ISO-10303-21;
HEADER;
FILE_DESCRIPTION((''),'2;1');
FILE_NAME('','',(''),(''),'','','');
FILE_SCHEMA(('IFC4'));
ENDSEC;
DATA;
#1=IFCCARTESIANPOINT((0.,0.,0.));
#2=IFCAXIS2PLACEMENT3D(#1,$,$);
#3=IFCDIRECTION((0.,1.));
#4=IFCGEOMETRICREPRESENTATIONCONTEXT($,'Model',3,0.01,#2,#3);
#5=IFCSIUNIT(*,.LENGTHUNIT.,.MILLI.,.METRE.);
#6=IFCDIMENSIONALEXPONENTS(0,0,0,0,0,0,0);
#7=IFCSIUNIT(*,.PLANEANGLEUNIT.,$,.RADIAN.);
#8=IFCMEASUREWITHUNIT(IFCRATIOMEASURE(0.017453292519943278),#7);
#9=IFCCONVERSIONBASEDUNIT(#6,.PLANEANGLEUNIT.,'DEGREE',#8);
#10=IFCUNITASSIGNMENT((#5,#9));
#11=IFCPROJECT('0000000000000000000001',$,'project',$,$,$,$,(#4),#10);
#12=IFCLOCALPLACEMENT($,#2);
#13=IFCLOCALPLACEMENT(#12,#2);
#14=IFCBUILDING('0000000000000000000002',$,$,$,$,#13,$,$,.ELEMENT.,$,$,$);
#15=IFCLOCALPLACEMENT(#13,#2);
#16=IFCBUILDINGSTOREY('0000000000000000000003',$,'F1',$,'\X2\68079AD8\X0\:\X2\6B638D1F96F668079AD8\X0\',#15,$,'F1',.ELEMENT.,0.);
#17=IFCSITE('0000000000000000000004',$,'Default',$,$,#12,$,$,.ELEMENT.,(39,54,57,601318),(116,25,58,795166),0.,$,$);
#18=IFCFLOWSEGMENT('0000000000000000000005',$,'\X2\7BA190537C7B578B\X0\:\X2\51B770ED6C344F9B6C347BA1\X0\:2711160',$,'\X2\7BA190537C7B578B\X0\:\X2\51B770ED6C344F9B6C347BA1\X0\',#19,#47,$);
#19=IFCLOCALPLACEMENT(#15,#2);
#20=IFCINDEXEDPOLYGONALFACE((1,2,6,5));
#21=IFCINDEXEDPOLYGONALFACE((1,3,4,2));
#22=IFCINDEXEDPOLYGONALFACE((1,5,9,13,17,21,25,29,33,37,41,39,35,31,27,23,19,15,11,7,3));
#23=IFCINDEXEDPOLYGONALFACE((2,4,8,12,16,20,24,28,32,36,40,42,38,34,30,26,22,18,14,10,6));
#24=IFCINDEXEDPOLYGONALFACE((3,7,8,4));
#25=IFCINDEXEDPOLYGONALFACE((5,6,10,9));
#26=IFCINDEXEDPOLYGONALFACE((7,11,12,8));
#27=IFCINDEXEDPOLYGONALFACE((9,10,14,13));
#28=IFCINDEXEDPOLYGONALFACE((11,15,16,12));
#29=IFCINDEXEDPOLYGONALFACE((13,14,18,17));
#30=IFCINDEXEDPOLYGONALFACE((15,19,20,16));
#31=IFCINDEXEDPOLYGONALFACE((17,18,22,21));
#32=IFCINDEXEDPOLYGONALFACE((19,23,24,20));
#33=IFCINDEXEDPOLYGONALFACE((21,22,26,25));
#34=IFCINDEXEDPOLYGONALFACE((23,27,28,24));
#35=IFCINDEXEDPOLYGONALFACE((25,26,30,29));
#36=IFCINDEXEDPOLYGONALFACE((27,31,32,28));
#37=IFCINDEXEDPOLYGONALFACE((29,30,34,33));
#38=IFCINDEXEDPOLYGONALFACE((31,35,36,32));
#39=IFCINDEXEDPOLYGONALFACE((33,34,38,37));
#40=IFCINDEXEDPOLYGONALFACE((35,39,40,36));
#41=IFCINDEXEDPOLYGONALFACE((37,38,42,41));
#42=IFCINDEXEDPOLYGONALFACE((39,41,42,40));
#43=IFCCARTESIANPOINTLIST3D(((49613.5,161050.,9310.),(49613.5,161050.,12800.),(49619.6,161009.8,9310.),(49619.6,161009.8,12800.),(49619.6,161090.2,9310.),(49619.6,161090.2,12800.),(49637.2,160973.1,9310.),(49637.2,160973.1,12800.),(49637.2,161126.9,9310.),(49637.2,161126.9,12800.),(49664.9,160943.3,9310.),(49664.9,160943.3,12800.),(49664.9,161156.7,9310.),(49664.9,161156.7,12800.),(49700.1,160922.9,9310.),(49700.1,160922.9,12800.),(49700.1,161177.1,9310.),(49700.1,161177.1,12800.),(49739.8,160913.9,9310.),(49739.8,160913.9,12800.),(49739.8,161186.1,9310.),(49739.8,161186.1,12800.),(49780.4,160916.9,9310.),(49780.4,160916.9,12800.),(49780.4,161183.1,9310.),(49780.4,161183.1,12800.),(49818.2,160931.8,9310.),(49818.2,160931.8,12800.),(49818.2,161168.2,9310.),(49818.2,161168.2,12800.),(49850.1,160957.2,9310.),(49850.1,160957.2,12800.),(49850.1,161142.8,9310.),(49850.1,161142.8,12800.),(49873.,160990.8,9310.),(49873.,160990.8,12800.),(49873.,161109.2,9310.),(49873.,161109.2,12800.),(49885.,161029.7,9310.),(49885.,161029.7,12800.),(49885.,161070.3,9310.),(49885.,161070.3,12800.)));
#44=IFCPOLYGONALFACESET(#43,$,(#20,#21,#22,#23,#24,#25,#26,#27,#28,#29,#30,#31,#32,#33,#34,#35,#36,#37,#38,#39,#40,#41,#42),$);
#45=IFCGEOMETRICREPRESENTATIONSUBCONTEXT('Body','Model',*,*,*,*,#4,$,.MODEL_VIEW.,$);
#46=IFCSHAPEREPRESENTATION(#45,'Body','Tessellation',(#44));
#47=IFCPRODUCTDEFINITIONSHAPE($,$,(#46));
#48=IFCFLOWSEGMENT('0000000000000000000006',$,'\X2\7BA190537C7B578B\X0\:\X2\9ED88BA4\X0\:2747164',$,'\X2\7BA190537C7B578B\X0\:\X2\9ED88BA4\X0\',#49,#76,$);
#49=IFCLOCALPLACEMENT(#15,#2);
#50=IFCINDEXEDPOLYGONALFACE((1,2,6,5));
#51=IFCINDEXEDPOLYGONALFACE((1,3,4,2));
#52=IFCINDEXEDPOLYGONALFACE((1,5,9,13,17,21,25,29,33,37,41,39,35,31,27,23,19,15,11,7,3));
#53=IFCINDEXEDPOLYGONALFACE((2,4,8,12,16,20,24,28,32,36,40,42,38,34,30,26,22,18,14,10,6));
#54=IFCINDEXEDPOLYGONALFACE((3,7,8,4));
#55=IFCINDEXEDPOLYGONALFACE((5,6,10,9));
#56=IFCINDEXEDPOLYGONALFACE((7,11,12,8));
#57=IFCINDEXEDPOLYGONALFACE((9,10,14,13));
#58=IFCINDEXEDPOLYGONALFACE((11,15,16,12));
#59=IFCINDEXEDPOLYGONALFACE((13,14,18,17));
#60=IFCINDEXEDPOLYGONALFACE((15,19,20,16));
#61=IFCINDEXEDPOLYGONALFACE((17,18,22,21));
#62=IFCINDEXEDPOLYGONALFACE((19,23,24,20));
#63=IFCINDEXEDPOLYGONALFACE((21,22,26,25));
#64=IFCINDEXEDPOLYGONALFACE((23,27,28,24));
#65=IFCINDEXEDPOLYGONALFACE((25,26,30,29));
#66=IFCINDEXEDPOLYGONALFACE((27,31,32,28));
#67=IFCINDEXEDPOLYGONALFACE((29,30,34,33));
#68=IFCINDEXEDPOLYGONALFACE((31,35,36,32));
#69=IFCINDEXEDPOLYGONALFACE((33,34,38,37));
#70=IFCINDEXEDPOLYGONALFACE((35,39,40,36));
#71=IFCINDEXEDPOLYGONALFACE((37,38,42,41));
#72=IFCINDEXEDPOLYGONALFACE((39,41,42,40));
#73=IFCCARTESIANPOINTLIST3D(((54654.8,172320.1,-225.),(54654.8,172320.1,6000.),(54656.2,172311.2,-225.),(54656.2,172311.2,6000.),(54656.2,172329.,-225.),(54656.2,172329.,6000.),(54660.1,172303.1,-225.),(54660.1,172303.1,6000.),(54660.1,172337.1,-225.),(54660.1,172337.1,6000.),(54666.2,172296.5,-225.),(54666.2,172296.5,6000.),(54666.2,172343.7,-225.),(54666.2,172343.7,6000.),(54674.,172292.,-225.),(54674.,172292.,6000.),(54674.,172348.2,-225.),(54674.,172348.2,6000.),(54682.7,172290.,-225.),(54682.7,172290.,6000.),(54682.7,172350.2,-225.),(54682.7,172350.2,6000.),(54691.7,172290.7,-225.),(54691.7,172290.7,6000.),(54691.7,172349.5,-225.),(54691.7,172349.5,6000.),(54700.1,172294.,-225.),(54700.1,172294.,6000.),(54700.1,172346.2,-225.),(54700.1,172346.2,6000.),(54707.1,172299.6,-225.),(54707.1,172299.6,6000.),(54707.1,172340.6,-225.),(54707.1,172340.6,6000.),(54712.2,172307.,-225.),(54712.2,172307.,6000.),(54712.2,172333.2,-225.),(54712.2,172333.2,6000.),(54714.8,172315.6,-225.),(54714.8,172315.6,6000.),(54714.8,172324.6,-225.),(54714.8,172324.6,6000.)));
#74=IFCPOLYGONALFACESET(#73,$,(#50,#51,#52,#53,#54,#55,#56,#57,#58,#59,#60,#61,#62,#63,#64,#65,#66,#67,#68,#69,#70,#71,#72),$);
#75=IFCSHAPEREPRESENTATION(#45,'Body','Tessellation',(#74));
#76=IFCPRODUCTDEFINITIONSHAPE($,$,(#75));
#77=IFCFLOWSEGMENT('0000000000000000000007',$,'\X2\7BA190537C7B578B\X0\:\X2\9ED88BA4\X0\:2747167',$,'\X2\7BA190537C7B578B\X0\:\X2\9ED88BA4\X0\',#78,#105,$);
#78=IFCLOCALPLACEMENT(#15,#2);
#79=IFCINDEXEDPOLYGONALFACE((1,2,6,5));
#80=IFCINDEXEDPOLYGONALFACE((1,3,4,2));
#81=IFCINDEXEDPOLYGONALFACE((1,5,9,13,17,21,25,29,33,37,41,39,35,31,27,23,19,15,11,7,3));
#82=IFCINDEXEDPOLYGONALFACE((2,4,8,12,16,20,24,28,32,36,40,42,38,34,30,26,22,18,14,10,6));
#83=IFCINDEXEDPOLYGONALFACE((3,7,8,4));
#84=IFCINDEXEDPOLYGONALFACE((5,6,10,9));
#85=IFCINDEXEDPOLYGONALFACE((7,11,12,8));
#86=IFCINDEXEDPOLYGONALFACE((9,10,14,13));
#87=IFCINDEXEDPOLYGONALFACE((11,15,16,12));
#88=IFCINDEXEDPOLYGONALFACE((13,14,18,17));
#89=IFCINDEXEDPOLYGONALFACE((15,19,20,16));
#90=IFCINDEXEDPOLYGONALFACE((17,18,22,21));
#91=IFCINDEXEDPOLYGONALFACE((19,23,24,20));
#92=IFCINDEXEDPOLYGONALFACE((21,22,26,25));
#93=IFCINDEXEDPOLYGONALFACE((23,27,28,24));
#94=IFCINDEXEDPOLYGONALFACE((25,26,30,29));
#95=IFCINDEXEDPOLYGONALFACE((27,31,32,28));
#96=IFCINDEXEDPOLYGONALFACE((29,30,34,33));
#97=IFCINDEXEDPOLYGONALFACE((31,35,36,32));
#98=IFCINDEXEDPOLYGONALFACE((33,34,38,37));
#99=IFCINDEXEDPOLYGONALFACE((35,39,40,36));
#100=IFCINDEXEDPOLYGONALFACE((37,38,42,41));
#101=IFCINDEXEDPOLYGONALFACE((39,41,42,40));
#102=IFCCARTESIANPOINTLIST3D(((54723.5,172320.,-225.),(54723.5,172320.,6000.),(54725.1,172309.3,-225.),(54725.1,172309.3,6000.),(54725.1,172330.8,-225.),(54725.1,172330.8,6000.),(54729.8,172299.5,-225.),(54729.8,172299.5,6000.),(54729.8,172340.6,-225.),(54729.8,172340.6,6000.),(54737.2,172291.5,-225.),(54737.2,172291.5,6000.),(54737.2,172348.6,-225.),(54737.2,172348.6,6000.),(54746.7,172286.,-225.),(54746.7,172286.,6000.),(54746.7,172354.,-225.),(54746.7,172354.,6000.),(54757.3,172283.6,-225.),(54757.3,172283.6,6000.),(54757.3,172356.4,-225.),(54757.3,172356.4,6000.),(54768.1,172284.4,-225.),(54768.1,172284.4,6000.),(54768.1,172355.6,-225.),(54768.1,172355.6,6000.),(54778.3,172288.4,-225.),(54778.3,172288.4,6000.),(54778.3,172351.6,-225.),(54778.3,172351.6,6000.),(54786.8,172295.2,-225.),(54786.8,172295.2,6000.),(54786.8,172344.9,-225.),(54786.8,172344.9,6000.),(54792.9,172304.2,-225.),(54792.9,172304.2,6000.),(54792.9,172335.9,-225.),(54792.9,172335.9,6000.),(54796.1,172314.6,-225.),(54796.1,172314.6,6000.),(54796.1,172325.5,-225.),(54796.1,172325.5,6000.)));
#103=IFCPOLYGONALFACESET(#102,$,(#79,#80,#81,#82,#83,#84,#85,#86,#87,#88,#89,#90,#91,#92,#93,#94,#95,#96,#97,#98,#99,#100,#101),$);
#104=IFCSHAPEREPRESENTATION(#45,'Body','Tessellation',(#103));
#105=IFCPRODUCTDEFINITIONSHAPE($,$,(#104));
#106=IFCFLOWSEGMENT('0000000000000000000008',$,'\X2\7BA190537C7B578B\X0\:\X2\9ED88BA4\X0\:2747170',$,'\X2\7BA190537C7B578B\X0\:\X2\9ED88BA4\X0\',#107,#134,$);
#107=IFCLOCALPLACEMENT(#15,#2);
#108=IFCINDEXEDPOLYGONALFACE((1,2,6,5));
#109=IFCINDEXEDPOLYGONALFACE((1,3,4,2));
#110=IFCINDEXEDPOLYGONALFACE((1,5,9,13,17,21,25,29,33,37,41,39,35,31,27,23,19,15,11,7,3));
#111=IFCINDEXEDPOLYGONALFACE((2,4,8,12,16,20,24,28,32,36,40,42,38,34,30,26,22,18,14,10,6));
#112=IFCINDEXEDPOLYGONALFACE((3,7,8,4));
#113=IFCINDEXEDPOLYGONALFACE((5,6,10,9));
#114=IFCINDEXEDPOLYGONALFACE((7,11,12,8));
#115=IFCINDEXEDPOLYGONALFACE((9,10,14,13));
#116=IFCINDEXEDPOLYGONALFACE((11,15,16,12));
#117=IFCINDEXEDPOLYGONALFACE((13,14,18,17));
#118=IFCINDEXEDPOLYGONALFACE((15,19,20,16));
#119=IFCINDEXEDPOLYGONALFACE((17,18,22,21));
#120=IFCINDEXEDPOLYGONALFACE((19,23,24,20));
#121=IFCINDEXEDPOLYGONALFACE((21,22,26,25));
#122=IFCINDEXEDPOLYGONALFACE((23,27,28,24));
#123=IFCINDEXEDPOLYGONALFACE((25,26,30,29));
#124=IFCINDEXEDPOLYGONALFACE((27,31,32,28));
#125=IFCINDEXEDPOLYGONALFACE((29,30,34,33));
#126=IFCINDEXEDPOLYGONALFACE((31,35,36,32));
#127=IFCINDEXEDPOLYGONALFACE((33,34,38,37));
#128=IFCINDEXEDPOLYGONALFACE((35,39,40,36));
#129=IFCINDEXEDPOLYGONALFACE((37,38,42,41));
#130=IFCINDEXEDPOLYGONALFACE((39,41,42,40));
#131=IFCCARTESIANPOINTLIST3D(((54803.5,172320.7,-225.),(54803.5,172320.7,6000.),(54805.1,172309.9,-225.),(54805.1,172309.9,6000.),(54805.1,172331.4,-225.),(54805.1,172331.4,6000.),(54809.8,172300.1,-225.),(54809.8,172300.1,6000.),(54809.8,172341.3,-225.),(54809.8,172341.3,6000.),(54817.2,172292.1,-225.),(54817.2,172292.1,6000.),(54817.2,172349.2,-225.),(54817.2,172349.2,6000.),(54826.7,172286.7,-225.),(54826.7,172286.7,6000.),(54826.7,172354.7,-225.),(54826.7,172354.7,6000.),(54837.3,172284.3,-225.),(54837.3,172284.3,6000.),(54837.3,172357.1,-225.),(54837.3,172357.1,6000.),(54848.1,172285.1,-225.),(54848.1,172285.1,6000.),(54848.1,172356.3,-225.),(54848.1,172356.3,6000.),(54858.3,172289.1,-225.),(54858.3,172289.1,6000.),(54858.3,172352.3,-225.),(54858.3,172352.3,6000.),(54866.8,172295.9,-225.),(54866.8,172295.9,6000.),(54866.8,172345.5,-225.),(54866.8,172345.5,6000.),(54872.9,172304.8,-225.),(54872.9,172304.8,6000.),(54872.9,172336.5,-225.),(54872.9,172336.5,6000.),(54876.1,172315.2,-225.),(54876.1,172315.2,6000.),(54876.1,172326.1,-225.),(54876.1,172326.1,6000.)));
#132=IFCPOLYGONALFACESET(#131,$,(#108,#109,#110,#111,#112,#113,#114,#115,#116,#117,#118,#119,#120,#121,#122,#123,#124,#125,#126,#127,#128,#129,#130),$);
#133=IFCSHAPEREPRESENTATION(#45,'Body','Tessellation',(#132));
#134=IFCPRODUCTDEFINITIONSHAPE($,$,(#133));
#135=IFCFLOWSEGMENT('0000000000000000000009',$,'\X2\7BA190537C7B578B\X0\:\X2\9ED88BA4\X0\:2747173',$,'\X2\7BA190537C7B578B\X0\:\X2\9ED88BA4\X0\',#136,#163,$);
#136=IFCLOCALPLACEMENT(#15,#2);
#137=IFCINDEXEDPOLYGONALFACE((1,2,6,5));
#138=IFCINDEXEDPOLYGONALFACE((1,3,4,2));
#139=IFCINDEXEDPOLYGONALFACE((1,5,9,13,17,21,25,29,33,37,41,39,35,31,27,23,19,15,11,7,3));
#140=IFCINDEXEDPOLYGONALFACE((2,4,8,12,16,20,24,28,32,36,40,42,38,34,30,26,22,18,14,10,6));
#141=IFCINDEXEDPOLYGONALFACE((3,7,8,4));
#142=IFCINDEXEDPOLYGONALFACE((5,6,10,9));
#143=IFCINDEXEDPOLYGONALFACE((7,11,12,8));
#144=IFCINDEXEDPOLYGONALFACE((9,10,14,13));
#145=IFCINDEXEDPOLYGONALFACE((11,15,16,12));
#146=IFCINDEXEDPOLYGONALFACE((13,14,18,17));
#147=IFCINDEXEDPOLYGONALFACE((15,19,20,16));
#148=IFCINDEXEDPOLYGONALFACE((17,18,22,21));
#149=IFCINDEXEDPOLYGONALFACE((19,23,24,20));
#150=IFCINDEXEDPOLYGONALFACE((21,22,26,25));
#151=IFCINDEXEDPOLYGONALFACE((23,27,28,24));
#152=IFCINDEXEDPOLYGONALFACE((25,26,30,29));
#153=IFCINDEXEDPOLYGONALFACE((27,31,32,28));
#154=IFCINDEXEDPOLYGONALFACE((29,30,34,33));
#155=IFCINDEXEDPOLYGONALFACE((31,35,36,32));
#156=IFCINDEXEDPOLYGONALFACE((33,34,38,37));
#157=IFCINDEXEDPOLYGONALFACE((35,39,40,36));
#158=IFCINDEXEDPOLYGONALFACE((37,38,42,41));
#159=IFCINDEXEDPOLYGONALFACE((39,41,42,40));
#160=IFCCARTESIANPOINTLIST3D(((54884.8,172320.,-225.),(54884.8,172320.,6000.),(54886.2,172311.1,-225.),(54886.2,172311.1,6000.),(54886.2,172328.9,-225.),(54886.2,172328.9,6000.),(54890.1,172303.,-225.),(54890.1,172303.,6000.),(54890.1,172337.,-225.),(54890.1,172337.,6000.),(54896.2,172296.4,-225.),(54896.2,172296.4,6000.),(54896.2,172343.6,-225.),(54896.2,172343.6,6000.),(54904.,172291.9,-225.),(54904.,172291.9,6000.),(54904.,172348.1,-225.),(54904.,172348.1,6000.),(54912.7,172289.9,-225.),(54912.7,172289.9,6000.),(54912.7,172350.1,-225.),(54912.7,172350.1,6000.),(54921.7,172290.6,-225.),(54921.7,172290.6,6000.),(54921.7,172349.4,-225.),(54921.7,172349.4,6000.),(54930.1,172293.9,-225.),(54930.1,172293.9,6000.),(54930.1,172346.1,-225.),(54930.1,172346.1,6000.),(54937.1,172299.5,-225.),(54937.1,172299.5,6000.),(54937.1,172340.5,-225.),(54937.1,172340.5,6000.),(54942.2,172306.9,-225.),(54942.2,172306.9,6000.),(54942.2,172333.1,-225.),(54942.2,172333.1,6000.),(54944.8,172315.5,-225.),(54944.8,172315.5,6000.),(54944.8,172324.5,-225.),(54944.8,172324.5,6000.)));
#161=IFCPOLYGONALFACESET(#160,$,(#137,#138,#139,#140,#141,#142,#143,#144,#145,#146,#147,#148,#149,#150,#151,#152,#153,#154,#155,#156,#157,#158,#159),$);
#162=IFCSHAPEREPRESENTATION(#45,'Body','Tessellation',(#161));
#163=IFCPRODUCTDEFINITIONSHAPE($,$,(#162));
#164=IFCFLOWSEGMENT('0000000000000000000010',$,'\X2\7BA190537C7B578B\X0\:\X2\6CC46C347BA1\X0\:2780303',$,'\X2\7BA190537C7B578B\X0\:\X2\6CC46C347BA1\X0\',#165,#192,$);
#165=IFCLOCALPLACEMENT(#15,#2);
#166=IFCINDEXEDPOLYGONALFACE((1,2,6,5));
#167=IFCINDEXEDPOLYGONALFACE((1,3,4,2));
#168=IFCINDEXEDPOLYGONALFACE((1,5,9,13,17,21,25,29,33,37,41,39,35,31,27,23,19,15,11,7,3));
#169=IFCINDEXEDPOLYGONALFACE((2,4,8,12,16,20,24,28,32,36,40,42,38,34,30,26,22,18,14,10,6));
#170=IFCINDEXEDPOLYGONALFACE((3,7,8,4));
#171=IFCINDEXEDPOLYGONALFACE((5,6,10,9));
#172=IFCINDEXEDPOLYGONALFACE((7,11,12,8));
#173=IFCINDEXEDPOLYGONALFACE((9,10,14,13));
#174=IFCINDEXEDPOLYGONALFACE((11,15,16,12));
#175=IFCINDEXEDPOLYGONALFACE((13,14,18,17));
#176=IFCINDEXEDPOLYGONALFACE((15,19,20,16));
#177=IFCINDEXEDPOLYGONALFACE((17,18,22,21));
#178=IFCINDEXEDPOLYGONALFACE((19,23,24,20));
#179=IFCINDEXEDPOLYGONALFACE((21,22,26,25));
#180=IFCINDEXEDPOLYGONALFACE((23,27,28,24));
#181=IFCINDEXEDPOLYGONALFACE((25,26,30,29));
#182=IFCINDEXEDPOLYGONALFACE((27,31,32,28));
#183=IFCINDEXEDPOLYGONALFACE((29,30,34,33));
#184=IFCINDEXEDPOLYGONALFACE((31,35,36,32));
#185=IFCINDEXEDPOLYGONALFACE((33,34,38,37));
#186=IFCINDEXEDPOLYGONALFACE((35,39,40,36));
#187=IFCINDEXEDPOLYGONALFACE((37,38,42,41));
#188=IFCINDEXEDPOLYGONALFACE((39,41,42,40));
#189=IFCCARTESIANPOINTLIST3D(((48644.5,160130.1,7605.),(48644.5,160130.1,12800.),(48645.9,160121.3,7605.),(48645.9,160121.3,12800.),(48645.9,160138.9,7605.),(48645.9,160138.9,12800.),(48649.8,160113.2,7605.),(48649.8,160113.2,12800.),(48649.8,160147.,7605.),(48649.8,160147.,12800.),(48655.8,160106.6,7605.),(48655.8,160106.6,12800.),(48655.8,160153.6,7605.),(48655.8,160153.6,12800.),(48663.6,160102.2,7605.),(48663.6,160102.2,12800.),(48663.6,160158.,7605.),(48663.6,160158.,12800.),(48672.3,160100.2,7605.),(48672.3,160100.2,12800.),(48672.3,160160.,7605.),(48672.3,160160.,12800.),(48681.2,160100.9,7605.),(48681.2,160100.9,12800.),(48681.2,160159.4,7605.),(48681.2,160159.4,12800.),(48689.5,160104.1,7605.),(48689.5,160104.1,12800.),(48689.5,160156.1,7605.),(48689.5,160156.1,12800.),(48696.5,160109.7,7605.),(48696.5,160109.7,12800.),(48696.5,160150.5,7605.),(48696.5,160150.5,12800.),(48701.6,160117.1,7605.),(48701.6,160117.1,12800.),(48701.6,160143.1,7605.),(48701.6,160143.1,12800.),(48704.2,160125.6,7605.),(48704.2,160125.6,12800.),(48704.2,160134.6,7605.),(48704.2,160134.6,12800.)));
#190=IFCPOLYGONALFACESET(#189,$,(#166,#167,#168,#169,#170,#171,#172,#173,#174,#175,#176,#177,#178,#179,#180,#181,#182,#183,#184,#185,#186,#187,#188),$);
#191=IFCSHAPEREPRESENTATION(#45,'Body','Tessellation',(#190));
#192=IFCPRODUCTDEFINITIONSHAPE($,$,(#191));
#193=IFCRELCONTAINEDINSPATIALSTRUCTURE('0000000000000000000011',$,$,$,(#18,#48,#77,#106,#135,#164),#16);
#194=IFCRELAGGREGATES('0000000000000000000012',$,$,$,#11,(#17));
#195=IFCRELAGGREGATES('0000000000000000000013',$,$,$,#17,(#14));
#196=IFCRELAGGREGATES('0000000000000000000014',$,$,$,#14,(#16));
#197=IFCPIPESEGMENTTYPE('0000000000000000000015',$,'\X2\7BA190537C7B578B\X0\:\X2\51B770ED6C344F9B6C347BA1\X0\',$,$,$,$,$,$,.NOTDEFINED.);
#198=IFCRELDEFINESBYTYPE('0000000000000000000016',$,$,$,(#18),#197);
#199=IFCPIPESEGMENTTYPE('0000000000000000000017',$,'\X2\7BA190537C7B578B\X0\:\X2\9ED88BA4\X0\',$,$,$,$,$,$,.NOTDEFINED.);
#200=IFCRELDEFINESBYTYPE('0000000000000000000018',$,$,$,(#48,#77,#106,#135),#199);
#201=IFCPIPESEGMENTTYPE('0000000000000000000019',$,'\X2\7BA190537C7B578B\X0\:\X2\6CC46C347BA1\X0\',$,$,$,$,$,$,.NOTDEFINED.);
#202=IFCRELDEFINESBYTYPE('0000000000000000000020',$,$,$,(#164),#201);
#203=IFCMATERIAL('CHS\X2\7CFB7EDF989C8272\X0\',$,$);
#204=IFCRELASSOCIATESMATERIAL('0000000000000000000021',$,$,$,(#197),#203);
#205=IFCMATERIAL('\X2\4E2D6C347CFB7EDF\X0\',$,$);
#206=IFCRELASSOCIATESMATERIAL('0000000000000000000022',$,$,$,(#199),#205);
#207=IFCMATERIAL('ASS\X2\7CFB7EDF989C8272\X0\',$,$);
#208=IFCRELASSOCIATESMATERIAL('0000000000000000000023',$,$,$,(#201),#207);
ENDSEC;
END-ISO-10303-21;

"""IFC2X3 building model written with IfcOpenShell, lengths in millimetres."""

from ifc_helpers import new_model, entity, si_unit, converted_unit, direction, frame, frame_2d, origin, origin_2d_with_axis, place, context, subcontext, project, spatial, circle, extrude, material, type_object, element, save


model = new_model("IFC2X3")

# Units and contexts
model_context = context("Model", 3, precision=0.01, world=origin(), true_north=direction((0.0, 1.0)))
body_context = subcontext(model_context, "Body", "Model", "MODEL_VIEW")
ifc_project = project(units=[si_unit("LENGTHUNIT", "METRE", prefix="MILLI"), converted_unit("PLANEANGLEUNIT", "DEGREE", entity("IfcRatioMeasure", 0.017453292519943278), si_unit("PLANEANGLEUNIT", "RADIAN"), dimensions=[0, 0, 0, 0, 0, 0, 0])], contexts=[model_context])

# Site, building, storey
site_placement = place(None, origin())
site = spatial("IfcSite", under=ifc_project, at=site_placement, Name="Default", CompositionType="ELEMENT", RefLatitude=(39, 54, 57, 601318), RefLongitude=(116, 25, 58, 795166), RefElevation=0.0)
building_placement = place(site_placement, origin())
building = spatial("IfcBuilding", under=site, at=building_placement, CompositionType="ELEMENT")
storey_placement = place(building_placement, origin())
storey = spatial("IfcBuildingStorey", under=building, at=storey_placement, Name="F1", ObjectType="标高:正负零标高", LongName="F1", CompositionType="ELEMENT", Elevation=0.0)

# Flow segments
ifc_material_1 = material(Name="ASS系统颜色")
ifc_material_2 = material(Name="CHS系统颜色")
pipe_segment_type_1 = type_object("IfcPipeSegmentType", Name="管道类型:冷热水供水管", PredefinedType="NOTDEFINED", material=ifc_material_2)
flow_segment_1_placement = place(storey_placement, origin())
element("IfcFlowSegment", 1, at=flow_segment_1_placement, inside=storey, type_object=pipe_segment_type_1, Name="管道类型:冷热水供水管:2711160", ObjectType="管道类型:冷热水供水管", context=body_context, shape_type="SweptSolid", body=[
    extrude(circle(Radius=136.5, at=origin_2d_with_axis()), frame((49750.0, 161050.0, 9310.0), z_axis=(0.0, 0.0, 1.0), x_axis=(-1.0, 0.0, 0.0)), (0.0, 0.0, 1.0), 3490.0),
])
ifc_material_3 = material(Name="中水系统")
pipe_segment_type_2 = type_object("IfcPipeSegmentType", Name="管道类型:默认", PredefinedType="NOTDEFINED", material=ifc_material_3)
flow_segment_2_placement = place(storey_placement, origin())
element("IfcFlowSegment", 2, at=flow_segment_2_placement, inside=storey, type_object=pipe_segment_type_2, Name="管道类型:默认:2747164", ObjectType="管道类型:默认", context=body_context, shape_type="SweptSolid", body=[
    extrude(circle(Radius=30.2, at=frame_2d((0.0, 0.0), x_axis=(1.0, 0.0))), frame((54685.0, 172320.1, -225.0), z_axis=(0.0, 0.0, 1.0), x_axis=(-1.0, 0.0, 0.0)), (0.0, 0.0, 1.0), 6225.0),
])
flow_segment_3_placement = place(storey_placement, origin())
element("IfcFlowSegment", 3, at=flow_segment_3_placement, inside=storey, type_object=pipe_segment_type_2, Name="管道类型:默认:2747167", ObjectType="管道类型:默认", context=body_context, shape_type="SweptSolid", body=[
    extrude(circle(Radius=36.5, at=origin_2d_with_axis()), frame((54760.0, 172320.0, -225.0), z_axis=(0.0, 0.0, 1.0), x_axis=(-1.0, 0.0, 0.0)), (0.0, 0.0, 1.0), 6225.0),
])
flow_segment_4_placement = place(storey_placement, origin())
element("IfcFlowSegment", 4, at=flow_segment_4_placement, inside=storey, type_object=pipe_segment_type_2, Name="管道类型:默认:2747170", ObjectType="管道类型:默认", context=body_context, shape_type="SweptSolid", body=[
    extrude(circle(Radius=36.5, at=frame_2d((0.0, 0.0), x_axis=(1.0, 0.0))), frame((54840.0, 172320.7, -225.0), z_axis=(0.0, 0.0, 1.0), x_axis=(-1.0, 0.0, 0.0)), (0.0, 0.0, 1.0), 6225.0),
])
flow_segment_5_placement = place(storey_placement, origin())
element("IfcFlowSegment", 5, at=flow_segment_5_placement, inside=storey, type_object=pipe_segment_type_2, Name="管道类型:默认:2747173", ObjectType="管道类型:默认", context=body_context, shape_type="SweptSolid", body=[
    extrude(circle(Radius=30.2, at=origin_2d_with_axis()), frame((54915.0, 172320.0, -225.0), z_axis=(0.0, 0.0, 1.0), x_axis=(-1.0, 0.0, 0.0)), (0.0, 0.0, 1.0), 6225.0),
])
pipe_segment_type_3 = type_object("IfcPipeSegmentType", Name="管道类型:泄水管", PredefinedType="NOTDEFINED", material=ifc_material_1)
flow_segment_6_placement = place(storey_placement, origin())
element("IfcFlowSegment", 6, at=flow_segment_6_placement, inside=storey, type_object=pipe_segment_type_3, Name="管道类型:泄水管:2780303", ObjectType="管道类型:泄水管", context=body_context, shape_type="SweptSolid", body=[
    extrude(circle(Radius=30.0, at=frame_2d((0.0, 0.0), x_axis=(1.0, 0.0))), frame((48674.5, 160130.1, 7605.0), z_axis=(0.0, 0.0, 1.0), x_axis=(-1.0, 0.0, 0.0)), (0.0, 0.0, 1.0), 5195.0),
])

save(model, "model.ifc")
